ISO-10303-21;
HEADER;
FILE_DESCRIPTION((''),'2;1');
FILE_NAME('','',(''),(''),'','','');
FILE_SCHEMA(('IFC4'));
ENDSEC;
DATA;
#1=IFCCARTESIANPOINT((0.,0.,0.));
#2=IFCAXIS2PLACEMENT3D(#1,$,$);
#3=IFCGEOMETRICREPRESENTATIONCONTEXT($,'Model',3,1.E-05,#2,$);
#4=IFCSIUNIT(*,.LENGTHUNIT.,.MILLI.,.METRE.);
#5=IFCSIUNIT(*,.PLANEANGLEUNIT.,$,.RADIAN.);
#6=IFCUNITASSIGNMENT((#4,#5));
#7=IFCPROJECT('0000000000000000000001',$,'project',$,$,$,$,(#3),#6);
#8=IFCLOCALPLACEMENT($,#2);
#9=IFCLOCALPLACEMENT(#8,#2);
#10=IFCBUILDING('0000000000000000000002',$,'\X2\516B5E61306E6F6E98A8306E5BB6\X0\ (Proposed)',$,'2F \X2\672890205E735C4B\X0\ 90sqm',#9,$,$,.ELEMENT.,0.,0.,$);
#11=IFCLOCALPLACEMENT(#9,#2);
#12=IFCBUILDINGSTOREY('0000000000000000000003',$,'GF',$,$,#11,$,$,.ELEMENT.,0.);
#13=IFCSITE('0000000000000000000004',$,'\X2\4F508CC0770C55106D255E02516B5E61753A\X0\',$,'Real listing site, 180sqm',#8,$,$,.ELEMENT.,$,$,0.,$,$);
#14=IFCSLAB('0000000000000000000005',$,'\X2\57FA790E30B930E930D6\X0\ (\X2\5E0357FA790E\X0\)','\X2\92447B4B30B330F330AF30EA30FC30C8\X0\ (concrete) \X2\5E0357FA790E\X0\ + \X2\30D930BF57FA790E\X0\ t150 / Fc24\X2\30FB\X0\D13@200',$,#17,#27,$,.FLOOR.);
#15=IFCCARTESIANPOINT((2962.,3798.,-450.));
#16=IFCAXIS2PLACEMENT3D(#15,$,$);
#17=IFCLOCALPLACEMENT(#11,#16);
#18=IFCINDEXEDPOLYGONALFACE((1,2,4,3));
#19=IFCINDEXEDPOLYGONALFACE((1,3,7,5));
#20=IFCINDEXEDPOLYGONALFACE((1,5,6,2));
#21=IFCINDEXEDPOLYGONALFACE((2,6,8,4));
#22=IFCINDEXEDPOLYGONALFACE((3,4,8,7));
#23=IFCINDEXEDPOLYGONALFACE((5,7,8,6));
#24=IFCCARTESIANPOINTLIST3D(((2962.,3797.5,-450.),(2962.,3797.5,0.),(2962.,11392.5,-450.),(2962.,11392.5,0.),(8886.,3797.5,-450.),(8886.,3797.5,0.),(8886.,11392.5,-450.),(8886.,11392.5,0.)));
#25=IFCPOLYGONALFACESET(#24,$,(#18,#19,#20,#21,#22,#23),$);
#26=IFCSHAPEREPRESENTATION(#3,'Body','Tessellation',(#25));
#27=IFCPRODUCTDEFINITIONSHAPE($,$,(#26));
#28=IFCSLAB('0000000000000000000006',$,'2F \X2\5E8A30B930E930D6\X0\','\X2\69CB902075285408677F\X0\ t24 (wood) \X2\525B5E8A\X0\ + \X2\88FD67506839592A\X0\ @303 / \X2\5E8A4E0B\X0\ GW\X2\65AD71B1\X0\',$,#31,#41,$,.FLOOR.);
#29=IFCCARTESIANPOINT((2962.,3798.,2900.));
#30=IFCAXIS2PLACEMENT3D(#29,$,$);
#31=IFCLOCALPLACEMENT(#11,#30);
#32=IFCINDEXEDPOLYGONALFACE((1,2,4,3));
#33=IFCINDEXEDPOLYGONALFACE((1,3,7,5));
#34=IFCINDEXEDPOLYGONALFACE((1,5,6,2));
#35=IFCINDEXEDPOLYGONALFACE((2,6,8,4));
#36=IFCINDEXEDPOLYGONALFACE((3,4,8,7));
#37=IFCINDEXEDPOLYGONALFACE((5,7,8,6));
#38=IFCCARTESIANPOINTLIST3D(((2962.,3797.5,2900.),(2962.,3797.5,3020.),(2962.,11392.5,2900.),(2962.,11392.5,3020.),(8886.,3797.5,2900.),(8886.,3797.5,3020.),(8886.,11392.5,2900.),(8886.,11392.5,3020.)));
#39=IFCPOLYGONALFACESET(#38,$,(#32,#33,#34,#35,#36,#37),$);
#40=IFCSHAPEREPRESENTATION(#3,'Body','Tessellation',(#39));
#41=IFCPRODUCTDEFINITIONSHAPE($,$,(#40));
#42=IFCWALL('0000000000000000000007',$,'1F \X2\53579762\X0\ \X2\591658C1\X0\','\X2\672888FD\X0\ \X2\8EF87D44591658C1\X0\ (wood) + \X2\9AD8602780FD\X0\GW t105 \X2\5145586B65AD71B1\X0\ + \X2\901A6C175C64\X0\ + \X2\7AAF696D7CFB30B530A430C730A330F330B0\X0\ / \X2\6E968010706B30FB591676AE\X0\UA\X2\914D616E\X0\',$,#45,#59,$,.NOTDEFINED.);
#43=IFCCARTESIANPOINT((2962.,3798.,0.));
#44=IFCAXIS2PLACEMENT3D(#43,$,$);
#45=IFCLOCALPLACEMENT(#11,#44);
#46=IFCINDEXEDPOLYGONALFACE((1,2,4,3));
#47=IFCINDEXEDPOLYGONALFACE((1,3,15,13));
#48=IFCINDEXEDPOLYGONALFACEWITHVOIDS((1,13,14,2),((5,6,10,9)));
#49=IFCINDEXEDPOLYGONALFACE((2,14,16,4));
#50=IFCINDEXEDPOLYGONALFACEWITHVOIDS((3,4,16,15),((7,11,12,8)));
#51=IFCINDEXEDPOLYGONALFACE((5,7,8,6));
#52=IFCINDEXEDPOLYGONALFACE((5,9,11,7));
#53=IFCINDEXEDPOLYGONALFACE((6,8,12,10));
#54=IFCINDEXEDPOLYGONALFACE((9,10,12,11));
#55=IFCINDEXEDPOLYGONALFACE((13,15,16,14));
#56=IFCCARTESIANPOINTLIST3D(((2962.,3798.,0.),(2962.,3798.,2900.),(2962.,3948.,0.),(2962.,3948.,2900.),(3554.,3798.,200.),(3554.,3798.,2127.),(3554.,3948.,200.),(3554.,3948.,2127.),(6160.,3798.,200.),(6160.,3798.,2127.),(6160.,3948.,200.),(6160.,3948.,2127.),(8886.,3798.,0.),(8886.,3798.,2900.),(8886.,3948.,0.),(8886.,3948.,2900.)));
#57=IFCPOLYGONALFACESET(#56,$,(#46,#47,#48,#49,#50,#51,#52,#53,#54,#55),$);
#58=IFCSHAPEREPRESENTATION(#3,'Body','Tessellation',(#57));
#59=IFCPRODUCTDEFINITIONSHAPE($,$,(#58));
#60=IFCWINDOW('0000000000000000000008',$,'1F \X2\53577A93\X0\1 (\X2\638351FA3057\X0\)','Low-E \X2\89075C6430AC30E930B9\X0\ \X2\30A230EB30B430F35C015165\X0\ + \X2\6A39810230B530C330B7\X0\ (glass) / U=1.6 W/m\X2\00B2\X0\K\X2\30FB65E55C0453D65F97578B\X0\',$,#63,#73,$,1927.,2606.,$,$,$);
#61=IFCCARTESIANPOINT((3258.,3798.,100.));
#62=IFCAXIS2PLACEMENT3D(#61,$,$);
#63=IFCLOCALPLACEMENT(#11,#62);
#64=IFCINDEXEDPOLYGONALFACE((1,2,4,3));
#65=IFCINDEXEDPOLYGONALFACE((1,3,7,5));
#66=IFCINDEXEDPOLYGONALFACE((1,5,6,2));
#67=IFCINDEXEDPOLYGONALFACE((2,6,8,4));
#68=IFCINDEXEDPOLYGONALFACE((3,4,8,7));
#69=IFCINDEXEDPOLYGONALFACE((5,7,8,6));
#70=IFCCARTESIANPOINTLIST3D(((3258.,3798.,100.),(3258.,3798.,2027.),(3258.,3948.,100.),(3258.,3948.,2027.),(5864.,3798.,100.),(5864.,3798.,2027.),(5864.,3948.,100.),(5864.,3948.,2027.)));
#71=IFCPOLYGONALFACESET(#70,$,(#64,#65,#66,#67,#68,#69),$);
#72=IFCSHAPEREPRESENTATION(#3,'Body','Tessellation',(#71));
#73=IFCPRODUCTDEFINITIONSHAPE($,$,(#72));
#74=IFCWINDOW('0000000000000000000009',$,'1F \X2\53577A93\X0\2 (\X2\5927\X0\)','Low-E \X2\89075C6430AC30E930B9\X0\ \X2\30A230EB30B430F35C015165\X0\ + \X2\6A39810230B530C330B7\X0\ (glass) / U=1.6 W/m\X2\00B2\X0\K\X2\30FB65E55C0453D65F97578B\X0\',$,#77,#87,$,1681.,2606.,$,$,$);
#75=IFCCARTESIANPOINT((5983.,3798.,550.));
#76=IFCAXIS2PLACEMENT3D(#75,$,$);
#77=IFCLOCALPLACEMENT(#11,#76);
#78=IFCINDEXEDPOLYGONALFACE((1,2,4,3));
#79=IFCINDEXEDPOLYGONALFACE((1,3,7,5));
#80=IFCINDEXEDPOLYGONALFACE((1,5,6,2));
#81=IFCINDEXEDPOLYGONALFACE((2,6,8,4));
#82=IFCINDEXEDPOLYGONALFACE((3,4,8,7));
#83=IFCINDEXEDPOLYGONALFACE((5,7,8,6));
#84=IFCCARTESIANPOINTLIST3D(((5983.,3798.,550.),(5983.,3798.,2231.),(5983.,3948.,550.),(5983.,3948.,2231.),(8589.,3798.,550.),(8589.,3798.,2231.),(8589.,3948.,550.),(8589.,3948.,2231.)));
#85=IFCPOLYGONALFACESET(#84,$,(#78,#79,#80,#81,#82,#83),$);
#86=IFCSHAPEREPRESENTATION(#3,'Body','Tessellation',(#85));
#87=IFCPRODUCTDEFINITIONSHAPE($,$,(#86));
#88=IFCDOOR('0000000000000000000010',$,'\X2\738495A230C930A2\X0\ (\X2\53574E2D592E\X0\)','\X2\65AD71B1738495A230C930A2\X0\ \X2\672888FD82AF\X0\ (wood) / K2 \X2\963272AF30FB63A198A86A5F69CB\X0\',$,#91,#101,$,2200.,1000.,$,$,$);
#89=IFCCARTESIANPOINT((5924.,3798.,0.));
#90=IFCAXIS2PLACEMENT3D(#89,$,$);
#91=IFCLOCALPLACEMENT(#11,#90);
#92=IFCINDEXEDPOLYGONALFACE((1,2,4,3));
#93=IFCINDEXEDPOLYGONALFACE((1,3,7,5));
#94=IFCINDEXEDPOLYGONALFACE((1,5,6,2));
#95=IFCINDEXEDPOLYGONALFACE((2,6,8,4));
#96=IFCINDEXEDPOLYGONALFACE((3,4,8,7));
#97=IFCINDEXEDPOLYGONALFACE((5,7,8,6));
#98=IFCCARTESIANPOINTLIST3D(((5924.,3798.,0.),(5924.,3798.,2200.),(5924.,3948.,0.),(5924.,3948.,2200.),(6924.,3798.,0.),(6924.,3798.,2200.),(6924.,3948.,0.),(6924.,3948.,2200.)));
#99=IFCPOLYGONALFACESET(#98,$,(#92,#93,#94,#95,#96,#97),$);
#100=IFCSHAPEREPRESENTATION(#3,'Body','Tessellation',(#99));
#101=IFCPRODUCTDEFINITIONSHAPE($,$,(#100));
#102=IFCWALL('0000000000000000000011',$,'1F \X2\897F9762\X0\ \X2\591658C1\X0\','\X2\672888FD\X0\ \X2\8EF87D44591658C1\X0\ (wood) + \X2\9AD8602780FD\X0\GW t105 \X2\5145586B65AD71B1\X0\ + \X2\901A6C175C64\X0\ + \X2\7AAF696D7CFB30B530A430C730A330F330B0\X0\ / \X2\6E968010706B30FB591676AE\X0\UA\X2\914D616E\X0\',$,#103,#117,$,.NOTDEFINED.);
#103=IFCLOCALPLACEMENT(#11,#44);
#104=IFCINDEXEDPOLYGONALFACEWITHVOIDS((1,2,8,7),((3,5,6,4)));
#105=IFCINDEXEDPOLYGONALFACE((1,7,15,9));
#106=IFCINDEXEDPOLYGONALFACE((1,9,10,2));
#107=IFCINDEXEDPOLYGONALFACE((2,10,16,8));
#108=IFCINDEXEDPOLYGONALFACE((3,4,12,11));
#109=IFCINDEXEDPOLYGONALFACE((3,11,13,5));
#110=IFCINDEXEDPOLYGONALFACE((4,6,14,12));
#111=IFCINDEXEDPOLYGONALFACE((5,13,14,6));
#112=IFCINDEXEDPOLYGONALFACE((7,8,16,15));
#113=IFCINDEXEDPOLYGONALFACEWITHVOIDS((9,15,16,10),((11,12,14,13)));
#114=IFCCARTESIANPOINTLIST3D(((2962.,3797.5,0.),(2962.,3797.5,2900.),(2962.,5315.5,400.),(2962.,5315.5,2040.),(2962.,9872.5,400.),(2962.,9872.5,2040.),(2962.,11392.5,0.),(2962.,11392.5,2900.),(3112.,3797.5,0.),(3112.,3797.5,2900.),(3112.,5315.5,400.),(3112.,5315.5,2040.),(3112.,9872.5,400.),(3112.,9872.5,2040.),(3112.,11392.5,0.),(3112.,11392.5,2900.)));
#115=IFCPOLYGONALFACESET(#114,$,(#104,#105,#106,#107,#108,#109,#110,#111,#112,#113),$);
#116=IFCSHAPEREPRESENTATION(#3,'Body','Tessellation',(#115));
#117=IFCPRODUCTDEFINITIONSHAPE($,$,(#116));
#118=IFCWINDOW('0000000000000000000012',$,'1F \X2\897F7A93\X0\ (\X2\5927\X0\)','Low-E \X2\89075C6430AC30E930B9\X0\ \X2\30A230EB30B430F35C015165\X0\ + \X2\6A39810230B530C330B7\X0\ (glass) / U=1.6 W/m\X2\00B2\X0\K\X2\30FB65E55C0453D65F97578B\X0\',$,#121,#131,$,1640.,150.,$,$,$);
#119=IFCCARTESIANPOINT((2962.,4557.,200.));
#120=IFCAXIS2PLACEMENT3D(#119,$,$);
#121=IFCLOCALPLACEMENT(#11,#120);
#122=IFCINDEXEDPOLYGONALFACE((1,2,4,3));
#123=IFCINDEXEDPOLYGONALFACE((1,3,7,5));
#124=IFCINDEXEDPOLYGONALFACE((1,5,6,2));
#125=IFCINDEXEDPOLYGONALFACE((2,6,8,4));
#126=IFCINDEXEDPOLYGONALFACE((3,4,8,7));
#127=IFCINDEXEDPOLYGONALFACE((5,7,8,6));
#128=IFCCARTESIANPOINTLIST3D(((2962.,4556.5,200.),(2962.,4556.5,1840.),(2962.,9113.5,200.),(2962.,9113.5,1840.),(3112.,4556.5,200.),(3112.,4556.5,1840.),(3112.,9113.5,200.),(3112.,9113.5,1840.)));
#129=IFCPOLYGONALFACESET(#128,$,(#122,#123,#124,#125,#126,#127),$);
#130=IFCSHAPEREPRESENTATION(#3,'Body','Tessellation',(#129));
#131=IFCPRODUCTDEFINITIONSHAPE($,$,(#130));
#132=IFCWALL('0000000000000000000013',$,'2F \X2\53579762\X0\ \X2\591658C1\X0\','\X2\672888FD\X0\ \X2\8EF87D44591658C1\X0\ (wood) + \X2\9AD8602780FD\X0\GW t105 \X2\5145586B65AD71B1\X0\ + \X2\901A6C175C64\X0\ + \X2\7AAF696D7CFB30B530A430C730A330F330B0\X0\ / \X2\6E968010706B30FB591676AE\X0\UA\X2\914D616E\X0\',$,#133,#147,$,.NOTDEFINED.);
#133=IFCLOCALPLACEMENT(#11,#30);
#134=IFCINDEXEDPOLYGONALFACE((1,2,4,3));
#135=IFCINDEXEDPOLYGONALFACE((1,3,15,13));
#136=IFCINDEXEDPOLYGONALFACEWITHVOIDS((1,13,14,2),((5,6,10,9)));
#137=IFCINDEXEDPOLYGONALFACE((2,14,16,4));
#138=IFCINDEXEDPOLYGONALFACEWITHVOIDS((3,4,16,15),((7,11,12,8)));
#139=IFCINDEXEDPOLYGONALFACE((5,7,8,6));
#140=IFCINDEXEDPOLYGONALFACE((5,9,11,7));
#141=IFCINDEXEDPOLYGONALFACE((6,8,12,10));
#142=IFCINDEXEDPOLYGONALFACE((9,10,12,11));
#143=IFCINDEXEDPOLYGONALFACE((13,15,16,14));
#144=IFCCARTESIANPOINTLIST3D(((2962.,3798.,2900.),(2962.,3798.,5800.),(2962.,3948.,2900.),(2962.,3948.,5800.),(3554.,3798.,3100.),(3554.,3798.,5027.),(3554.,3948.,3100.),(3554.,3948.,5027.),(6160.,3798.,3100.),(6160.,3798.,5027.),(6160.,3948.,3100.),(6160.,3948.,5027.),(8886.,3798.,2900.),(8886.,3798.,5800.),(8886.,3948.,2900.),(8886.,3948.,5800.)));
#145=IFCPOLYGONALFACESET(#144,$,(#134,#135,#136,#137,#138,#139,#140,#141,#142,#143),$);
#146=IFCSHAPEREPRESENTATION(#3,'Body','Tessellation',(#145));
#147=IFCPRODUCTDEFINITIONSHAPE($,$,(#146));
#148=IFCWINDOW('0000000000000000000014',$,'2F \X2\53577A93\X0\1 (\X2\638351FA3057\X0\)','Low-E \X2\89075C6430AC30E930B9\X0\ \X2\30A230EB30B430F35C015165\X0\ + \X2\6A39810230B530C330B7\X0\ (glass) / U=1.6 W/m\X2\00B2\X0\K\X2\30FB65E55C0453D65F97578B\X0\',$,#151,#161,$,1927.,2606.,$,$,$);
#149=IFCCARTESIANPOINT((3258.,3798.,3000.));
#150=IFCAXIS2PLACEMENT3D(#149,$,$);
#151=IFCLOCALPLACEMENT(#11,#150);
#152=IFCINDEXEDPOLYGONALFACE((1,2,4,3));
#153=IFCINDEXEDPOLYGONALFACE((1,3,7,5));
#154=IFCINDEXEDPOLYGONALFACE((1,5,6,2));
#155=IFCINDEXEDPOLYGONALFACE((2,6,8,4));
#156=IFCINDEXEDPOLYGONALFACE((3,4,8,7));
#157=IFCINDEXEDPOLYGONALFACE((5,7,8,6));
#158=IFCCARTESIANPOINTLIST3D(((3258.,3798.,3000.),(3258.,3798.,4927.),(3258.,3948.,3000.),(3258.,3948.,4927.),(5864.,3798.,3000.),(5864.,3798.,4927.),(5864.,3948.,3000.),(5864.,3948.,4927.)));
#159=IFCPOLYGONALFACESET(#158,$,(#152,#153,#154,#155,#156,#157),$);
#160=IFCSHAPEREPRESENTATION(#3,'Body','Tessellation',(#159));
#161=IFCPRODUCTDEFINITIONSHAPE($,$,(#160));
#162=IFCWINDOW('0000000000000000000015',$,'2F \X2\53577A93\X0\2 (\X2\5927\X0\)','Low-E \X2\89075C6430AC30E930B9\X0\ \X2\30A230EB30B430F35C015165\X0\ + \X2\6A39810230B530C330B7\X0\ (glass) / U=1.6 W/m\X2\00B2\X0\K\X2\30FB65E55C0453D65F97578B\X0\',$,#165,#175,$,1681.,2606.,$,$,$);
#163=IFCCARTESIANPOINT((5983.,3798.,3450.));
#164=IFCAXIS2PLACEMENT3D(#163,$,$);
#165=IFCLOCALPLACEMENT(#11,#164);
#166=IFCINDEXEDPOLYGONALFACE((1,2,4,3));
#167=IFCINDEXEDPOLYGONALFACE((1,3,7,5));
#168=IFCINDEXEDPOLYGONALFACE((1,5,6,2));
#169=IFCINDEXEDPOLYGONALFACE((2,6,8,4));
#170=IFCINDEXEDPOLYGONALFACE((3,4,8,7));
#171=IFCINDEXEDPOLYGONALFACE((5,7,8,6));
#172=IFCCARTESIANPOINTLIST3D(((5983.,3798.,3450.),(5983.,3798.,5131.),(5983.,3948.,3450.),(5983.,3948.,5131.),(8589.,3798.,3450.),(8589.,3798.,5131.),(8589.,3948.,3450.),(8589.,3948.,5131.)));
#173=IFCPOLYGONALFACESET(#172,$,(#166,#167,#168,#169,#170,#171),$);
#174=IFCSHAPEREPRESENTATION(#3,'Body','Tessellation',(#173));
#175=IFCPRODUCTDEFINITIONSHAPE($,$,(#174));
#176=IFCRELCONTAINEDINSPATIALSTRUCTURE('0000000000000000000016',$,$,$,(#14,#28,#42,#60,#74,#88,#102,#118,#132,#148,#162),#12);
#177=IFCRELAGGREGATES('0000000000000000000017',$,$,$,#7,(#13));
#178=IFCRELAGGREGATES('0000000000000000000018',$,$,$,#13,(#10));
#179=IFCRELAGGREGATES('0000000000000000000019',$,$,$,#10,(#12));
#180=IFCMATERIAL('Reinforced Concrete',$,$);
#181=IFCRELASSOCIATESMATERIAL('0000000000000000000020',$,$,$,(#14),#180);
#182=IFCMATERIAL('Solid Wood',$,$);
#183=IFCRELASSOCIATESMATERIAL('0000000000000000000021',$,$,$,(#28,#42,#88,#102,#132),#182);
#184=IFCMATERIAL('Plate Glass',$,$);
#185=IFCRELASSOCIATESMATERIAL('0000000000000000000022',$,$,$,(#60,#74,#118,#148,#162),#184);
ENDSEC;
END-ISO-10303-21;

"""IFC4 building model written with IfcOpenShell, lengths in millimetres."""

from ifc_helpers import new_model, si_unit, frame, frame_2d, origin, place, context, project, spatial, rectangle, extrude, material, element, fill, save


model = new_model("IFC4")

# Units and contexts
model_context = context("Model", 3, precision=1e-05, world=origin())
ifc_project = project(units=[si_unit("LENGTHUNIT", "METRE", prefix="MILLI"), si_unit("PLANEANGLEUNIT", "RADIAN")], contexts=[model_context])

# Site, building, storey
site_placement = place(None, origin())
site = spatial("IfcSite", under=ifc_project, at=site_placement, Name="佐賀県唐津市八幡町", ObjectType="Real listing site, 180sqm", CompositionType="ELEMENT", RefElevation=0.0)
building_placement = place(site_placement, origin())
building = spatial("IfcBuilding", under=site, at=building_placement, Name="八幡の潮風の家 (Proposed)", ObjectType="2F 木造平屋 90sqm", CompositionType="ELEMENT", ElevationOfRefHeight=0.0, ElevationOfTerrain=0.0)
storey_placement = place(building_placement, origin())
storey = spatial("IfcBuildingStorey", under=building, at=storey_placement, Name="GF", CompositionType="ELEMENT", Elevation=0.0)

# Slabs
ifc_material_1 = material(Name="Reinforced Concrete")
slab_1_placement = place(storey_placement, frame((2962.0, 3798.0, -450.0)))
element("IfcSlab", 1, at=slab_1_placement, inside=storey, material=ifc_material_1, Name="基礎スラブ (布基礎)", Description="鉄筋コンクリート (concrete) 布基礎 + ベタ基礎 t150 / Fc24・D13@200", PredefinedType="FLOOR", context=model_context, shape_type="SweptSolid", body=[
    extrude(rectangle(XDim=5924.0, YDim=7595.0, at=frame_2d((2962.0, 3797.0))), frame((2962.0, 3798.0, -450.0)), (0.0, 0.0, 1.0), 450.0),
])
ifc_material_2 = material(Name="Solid Wood")
slab_2_placement = place(storey_placement, frame((2962.0, 3798.0, 2900.0)))
element("IfcSlab", 2, at=slab_2_placement, inside=storey, material=ifc_material_2, Name="2F 床スラブ", Description="構造用合板 t24 (wood) 剛床 + 製材根太 @303 / 床下 GW断熱", PredefinedType="FLOOR", context=model_context, shape_type="SweptSolid", body=[
    extrude(rectangle(XDim=5924.0, YDim=7595.0, at=frame_2d((2962.0, 3797.0))), frame((2962.0, 3798.0, 2900.0)), (0.0, 0.0, 1.0), 120.0),
])

# Wall, openings, windows, door
wall_1_placement = place(storey_placement, frame((2962.0, 3798.0, 0.0)))
wall_1 = element("IfcWall", 3, at=wall_1_placement, inside=storey, material=ifc_material_2, Name="1F 南面 外壁", Description="木製 軸組外壁 (wood) + 高性能GW t105 充填断熱 + 通気層 + 窯業系サイディング / 準耐火・外皮UA配慮", PredefinedType="NOTDEFINED", context=model_context, shape_type="SweptSolid", body=[
    extrude(rectangle(XDim=5924.0, YDim=150.0, at=frame_2d((2962.0, 75.0))), frame((2962.0, 3798.0, 0.0)), (0.0, 0.0, 1.0), 2900.0),
])
opening_1_placement = place(storey_placement, frame((3258.0, 3798.0, 100.0)))
opening_1 = element("IfcOpeningElement", 4, at=opening_1_placement, cuts=wall_1, PredefinedType="NOTDEFINED", context=model_context, shape_type="SweptSolid", body=[
    extrude(rectangle(XDim=2606.0, YDim=150.0, at=frame_2d((1303.0, 75.0))), frame((3258.0, 3798.0, 100.0)), (0.0, 0.0, 1.0), 1927.0),
])
opening_2_placement = place(storey_placement, frame((5983.0, 3798.0, 550.0)))
opening_2 = element("IfcOpeningElement", 5, at=opening_2_placement, cuts=wall_1, PredefinedType="NOTDEFINED", context=model_context, shape_type="SweptSolid", body=[
    extrude(rectangle(XDim=2606.0, YDim=150.0, at=frame_2d((1303.0, 75.0))), frame((5983.0, 3798.0, 550.0)), (0.0, 0.0, 1.0), 1681.0),
])
opening_3_placement = place(storey_placement, frame((5924.0, 3798.0, 0.0)))
opening_3 = element("IfcOpeningElement", 6, at=opening_3_placement, cuts=wall_1, PredefinedType="NOTDEFINED", context=model_context, shape_type="SweptSolid", body=[
    extrude(rectangle(XDim=1000.0, YDim=150.0, at=frame_2d((500.0, 75.0))), frame((5924.0, 3798.0, 0.0)), (0.0, 0.0, 1.0), 2200.0),
])
ifc_material_3 = material(Name="Plate Glass")
window_1_placement = place(storey_placement, frame((3258.0, 3798.0, 100.0)))
window_1 = element("IfcWindow", 7, at=window_1_placement, inside=storey, material=ifc_material_3, Name="1F 南窓1 (掃出し)", Description="Low-E 複層ガラス アルゴン封入 + 樹脂サッシ (glass) / U=1.6 W/m²K・日射取得型", OverallHeight=1927.0, OverallWidth=2606.0, context=model_context, shape_type="SweptSolid", body=[
    extrude(rectangle(XDim=2606.0, YDim=150.0, at=frame_2d((1303.0, 75.0))), frame((3258.0, 3798.0, 100.0)), (0.0, 0.0, 1.0), 1927.0),
])
fill(opening_1, window_1)
window_2_placement = place(storey_placement, frame((5983.0, 3798.0, 550.0)))
window_2 = element("IfcWindow", 8, at=window_2_placement, inside=storey, material=ifc_material_3, Name="1F 南窓2 (大)", Description="Low-E 複層ガラス アルゴン封入 + 樹脂サッシ (glass) / U=1.6 W/m²K・日射取得型", OverallHeight=1681.0, OverallWidth=2606.0, context=model_context, shape_type="SweptSolid", body=[
    extrude(rectangle(XDim=2606.0, YDim=150.0, at=frame_2d((1303.0, 75.0))), frame((5983.0, 3798.0, 550.0)), (0.0, 0.0, 1.0), 1681.0),
])
fill(opening_2, window_2)
door_placement = place(storey_placement, frame((5924.0, 3798.0, 0.0)))
door = element("IfcDoor", 9, at=door_placement, inside=storey, material=ifc_material_2, Name="玄関ドア (南中央)", Description="断熱玄関ドア 木製芯 (wood) / K2 防犯・採風機構", OverallHeight=2200.0, OverallWidth=1000.0, context=model_context, shape_type="SweptSolid", body=[
    extrude(rectangle(XDim=1000.0, YDim=150.0, at=frame_2d((500.0, 75.0))), frame((5924.0, 3798.0, 0.0)), (0.0, 0.0, 1.0), 2200.0),
])
fill(opening_3, door)

# Wall, opening, window
wall_2_placement = place(storey_placement, frame((2962.0, 3798.0, 0.0)))
wall_2 = element("IfcWall", 10, at=wall_2_placement, inside=storey, material=ifc_material_2, Name="1F 西面 外壁", Description="木製 軸組外壁 (wood) + 高性能GW t105 充填断熱 + 通気層 + 窯業系サイディング / 準耐火・外皮UA配慮", PredefinedType="NOTDEFINED", context=model_context, shape_type="SweptSolid", body=[
    extrude(rectangle(XDim=150.0, YDim=7595.0, at=frame_2d((75.0, 3797.0))), frame((2962.0, 3798.0, 0.0)), (0.0, 0.0, 1.0), 2900.0),
])
opening_4_placement = place(storey_placement, frame((2962.0, 4557.0, 200.0)))
opening_4 = element("IfcOpeningElement", 11, at=opening_4_placement, cuts=wall_2, PredefinedType="NOTDEFINED", context=model_context, shape_type="SweptSolid", body=[
    extrude(rectangle(XDim=150.0, YDim=4557.0, at=frame_2d((75.0, 2278.0))), frame((2962.0, 4557.0, 200.0)), (0.0, 0.0, 1.0), 1640.0),
])
window_3_placement = place(storey_placement, frame((2962.0, 4557.0, 200.0)))
window_3 = element("IfcWindow", 12, at=window_3_placement, inside=storey, material=ifc_material_3, Name="1F 西窓 (大)", Description="Low-E 複層ガラス アルゴン封入 + 樹脂サッシ (glass) / U=1.6 W/m²K・日射取得型", OverallHeight=1640.0, OverallWidth=150.0, context=model_context, shape_type="SweptSolid", body=[
    extrude(rectangle(XDim=150.0, YDim=4557.0, at=frame_2d((75.0, 2278.0))), frame((2962.0, 4557.0, 200.0)), (0.0, 0.0, 1.0), 1640.0),
])
fill(opening_4, window_3)

# Wall, openings, windows
wall_3_placement = place(storey_placement, frame((2962.0, 3798.0, 2900.0)))
wall_3 = element("IfcWall", 13, at=wall_3_placement, inside=storey, material=ifc_material_2, Name="2F 南面 外壁", Description="木製 軸組外壁 (wood) + 高性能GW t105 充填断熱 + 通気層 + 窯業系サイディング / 準耐火・外皮UA配慮", PredefinedType="NOTDEFINED", context=model_context, shape_type="SweptSolid", body=[
    extrude(rectangle(XDim=5924.0, YDim=150.0, at=frame_2d((2962.0, 75.0))), frame((2962.0, 3798.0, 2900.0)), (0.0, 0.0, 1.0), 2900.0),
])
opening_5_placement = place(storey_placement, frame((3258.0, 3798.0, 3000.0)))
opening_5 = element("IfcOpeningElement", 14, at=opening_5_placement, cuts=wall_3, PredefinedType="NOTDEFINED", context=model_context, shape_type="SweptSolid", body=[
    extrude(rectangle(XDim=2606.0, YDim=150.0, at=frame_2d((1303.0, 75.0))), frame((3258.0, 3798.0, 3000.0)), (0.0, 0.0, 1.0), 1927.0),
])
opening_6_placement = place(storey_placement, frame((5983.0, 3798.0, 3450.0)))
opening_6 = element("IfcOpeningElement", 15, at=opening_6_placement, cuts=wall_3, PredefinedType="NOTDEFINED", context=model_context, shape_type="SweptSolid", body=[
    extrude(rectangle(XDim=2606.0, YDim=150.0, at=frame_2d((1303.0, 75.0))), frame((5983.0, 3798.0, 3450.0)), (0.0, 0.0, 1.0), 1681.0),
])
window_4_placement = place(storey_placement, frame((3258.0, 3798.0, 3000.0)))
window_4 = element("IfcWindow", 16, at=window_4_placement, inside=storey, material=ifc_material_3, Name="2F 南窓1 (掃出し)", Description="Low-E 複層ガラス アルゴン封入 + 樹脂サッシ (glass) / U=1.6 W/m²K・日射取得型", OverallHeight=1927.0, OverallWidth=2606.0, context=model_context, shape_type="SweptSolid", body=[
    extrude(rectangle(XDim=2606.0, YDim=150.0, at=frame_2d((1303.0, 75.0))), frame((3258.0, 3798.0, 3000.0)), (0.0, 0.0, 1.0), 1927.0),
])
fill(opening_5, window_4)
window_5_placement = place(storey_placement, frame((5983.0, 3798.0, 3450.0)))
window_5 = element("IfcWindow", 17, at=window_5_placement, inside=storey, material=ifc_material_3, Name="2F 南窓2 (大)", Description="Low-E 複層ガラス アルゴン封入 + 樹脂サッシ (glass) / U=1.6 W/m²K・日射取得型", OverallHeight=1681.0, OverallWidth=2606.0, context=model_context, shape_type="SweptSolid", body=[
    extrude(rectangle(XDim=2606.0, YDim=150.0, at=frame_2d((1303.0, 75.0))), frame((5983.0, 3798.0, 3450.0)), (0.0, 0.0, 1.0), 1681.0),
])
fill(opening_6, window_5)

save(model, "model.ifc")
